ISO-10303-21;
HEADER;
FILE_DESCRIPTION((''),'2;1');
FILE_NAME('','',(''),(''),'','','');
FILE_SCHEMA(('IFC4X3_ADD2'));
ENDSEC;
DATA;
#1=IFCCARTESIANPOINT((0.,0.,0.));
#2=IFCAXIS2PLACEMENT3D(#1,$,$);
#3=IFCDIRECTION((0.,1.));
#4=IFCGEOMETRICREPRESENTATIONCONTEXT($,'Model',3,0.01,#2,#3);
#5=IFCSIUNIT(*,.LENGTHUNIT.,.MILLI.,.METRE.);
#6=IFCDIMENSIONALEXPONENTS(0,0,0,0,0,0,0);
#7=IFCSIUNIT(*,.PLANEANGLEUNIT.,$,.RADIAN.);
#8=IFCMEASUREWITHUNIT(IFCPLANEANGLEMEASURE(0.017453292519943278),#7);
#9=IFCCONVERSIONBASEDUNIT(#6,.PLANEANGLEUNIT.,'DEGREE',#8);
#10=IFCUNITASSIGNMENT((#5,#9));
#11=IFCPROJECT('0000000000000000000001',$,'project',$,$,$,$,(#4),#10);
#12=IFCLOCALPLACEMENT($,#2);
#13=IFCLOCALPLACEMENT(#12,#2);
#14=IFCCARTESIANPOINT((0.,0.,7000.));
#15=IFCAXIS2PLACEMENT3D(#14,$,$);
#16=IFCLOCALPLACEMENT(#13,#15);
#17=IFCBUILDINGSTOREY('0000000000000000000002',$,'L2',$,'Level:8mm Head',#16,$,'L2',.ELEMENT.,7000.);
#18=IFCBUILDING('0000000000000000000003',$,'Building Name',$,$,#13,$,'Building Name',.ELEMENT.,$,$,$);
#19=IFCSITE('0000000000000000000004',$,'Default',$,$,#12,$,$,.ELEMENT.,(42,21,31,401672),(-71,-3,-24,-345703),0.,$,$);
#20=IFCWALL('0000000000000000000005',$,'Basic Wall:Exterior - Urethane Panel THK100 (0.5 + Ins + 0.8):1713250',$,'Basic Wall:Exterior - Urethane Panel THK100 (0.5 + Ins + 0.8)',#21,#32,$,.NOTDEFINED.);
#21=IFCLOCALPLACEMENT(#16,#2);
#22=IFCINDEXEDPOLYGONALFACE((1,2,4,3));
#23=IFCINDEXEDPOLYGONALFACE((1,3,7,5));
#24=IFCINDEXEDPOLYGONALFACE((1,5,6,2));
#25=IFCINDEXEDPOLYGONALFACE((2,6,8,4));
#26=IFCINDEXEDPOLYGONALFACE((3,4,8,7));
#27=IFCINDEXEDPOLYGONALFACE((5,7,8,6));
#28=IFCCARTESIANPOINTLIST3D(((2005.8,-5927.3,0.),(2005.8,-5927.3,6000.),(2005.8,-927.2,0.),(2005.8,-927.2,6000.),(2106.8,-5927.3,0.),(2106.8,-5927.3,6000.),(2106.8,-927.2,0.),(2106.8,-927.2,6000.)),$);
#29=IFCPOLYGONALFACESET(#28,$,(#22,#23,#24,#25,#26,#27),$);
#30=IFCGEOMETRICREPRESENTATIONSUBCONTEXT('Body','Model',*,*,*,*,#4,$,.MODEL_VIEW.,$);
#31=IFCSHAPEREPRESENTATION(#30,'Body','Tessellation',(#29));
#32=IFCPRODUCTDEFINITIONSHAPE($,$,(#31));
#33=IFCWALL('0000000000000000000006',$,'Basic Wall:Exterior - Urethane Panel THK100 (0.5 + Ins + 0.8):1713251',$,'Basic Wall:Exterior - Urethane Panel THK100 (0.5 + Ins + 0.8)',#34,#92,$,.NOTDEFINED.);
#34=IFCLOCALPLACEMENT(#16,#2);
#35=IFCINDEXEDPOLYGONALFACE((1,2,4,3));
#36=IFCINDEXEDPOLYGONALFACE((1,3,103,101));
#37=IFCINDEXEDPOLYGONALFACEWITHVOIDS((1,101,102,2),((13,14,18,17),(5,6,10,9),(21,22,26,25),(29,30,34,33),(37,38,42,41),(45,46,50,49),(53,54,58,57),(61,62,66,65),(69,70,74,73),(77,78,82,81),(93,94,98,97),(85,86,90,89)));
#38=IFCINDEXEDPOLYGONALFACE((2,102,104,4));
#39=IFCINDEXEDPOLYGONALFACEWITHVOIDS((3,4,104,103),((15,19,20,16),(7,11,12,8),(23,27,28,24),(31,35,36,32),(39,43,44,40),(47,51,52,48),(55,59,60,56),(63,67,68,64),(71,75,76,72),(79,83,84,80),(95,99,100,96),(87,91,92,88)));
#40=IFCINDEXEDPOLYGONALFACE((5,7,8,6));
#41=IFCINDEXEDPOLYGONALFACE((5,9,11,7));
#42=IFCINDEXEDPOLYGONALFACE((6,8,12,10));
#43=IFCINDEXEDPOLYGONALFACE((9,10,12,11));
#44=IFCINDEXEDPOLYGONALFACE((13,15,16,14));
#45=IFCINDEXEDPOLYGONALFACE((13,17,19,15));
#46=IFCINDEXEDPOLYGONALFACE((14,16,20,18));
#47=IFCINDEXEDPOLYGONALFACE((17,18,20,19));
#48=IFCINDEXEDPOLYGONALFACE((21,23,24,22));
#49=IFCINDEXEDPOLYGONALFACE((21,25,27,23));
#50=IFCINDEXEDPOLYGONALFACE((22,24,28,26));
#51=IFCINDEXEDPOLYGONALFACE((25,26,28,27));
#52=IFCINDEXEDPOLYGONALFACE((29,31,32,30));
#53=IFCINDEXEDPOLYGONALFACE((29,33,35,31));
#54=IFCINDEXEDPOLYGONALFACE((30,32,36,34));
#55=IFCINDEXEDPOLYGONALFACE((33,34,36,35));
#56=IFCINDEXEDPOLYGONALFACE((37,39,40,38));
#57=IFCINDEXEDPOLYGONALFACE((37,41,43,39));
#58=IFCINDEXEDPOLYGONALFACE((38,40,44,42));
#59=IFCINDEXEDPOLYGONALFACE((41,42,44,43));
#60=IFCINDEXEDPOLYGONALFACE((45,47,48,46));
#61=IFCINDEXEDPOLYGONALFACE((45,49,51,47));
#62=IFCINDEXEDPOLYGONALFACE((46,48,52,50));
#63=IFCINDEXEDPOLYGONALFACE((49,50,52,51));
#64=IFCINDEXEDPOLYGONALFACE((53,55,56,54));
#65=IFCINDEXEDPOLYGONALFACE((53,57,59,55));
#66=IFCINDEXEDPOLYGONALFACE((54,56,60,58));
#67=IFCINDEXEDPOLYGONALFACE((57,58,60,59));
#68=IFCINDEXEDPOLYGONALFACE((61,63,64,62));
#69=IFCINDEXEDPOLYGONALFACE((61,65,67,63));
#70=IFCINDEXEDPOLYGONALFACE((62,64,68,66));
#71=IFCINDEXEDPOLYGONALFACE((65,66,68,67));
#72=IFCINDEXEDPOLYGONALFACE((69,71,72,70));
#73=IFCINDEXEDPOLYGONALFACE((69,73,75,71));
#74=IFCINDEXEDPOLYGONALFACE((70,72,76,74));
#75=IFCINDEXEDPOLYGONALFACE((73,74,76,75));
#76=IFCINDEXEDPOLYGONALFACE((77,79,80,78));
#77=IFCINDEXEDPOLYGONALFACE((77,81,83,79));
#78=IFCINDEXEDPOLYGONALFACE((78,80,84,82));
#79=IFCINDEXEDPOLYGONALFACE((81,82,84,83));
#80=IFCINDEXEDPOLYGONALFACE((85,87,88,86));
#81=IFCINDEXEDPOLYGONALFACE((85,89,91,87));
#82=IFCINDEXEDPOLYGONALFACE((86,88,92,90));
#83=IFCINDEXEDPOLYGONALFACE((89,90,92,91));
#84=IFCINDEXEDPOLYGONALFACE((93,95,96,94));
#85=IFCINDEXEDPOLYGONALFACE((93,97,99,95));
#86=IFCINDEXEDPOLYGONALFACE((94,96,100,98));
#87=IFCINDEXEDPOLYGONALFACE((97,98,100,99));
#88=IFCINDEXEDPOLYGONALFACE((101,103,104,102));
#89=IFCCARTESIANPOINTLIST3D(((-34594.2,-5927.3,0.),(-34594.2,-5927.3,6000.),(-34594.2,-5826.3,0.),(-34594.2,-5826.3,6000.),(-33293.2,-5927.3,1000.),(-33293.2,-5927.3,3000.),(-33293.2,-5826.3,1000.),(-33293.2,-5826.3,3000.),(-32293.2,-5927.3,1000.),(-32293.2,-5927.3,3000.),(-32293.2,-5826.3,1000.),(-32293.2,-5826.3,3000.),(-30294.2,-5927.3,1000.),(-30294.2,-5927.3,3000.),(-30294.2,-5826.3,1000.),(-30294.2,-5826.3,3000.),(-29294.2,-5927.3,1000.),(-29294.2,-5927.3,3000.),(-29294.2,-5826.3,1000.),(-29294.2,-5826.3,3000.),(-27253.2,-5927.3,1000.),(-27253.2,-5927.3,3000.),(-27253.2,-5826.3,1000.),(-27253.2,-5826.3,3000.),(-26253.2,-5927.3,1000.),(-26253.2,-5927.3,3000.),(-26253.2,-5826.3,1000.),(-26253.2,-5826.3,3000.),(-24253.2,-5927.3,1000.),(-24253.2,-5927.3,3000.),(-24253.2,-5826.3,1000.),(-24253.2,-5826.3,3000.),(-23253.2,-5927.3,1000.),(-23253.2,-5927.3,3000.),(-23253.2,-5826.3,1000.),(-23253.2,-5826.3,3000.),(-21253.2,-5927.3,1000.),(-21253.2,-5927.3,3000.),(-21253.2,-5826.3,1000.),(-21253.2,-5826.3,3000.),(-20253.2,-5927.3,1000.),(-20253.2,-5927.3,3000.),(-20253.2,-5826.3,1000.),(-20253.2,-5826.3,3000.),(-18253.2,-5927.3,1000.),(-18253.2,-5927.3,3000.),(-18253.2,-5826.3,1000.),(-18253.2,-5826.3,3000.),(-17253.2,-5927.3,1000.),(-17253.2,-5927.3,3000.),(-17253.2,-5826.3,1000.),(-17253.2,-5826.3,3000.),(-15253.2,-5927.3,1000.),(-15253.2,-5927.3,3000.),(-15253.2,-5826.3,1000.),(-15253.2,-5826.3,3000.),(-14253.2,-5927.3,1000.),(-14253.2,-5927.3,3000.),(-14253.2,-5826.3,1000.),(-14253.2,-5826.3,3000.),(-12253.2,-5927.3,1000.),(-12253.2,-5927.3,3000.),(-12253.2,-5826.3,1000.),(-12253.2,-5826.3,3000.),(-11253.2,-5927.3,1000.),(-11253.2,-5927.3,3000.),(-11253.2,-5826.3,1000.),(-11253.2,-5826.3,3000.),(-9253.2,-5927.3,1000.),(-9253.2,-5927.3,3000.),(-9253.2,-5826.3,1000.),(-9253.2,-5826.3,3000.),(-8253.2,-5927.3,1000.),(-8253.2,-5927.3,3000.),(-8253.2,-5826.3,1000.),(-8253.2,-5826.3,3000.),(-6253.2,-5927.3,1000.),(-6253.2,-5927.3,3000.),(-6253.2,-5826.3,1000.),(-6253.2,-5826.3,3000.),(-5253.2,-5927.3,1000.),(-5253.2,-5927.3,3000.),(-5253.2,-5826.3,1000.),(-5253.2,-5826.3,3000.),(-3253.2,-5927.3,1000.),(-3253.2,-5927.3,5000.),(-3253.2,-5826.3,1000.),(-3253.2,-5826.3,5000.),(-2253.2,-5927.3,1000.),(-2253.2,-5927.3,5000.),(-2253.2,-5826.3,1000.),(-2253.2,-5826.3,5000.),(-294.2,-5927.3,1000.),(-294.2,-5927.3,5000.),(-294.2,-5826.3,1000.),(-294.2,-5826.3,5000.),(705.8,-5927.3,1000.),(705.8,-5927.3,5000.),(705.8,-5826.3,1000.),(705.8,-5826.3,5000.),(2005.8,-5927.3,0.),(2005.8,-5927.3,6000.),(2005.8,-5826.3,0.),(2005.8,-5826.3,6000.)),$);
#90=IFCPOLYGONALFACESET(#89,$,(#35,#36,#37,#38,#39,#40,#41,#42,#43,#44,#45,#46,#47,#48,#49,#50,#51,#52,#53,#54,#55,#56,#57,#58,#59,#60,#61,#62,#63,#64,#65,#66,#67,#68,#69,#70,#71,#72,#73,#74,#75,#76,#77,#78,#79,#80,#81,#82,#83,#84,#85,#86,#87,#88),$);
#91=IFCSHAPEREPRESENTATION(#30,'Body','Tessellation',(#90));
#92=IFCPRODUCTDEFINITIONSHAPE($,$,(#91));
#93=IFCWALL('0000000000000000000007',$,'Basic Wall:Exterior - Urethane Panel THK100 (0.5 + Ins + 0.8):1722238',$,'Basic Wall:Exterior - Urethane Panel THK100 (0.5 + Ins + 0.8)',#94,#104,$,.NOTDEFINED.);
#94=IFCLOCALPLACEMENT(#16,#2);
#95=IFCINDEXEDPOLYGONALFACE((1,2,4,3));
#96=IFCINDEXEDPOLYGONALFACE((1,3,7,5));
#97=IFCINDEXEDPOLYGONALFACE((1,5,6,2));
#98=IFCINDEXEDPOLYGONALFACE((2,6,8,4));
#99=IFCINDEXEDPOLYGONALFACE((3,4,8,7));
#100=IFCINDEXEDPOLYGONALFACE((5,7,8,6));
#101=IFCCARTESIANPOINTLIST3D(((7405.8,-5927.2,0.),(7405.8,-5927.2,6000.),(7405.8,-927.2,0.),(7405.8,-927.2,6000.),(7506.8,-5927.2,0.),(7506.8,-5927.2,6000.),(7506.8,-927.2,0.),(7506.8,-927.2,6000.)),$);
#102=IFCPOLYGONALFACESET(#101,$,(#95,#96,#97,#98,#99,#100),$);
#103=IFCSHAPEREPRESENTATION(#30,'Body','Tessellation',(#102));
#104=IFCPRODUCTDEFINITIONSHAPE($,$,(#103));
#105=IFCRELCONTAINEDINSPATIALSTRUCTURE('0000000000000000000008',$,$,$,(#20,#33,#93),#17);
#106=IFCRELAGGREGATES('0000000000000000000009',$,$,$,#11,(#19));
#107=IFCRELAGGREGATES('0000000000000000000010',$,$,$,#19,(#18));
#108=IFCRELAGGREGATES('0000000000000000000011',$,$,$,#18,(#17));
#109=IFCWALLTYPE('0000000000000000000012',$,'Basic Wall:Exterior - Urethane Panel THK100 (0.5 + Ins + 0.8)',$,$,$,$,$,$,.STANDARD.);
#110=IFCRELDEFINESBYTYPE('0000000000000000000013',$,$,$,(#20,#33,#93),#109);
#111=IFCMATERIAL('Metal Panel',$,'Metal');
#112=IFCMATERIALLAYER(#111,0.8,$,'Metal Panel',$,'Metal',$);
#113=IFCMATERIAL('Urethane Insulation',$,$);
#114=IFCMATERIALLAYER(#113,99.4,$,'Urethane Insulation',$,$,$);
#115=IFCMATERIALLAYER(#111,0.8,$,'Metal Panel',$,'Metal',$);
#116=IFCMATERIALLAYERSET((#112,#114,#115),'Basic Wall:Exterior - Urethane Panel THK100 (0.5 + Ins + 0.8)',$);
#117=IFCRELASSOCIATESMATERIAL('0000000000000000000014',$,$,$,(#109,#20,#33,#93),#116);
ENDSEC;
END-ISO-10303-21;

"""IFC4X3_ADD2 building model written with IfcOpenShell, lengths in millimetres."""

from ifc_helpers import new_model, entity, si_unit, converted_unit, direction, frame, frame_2d, origin, place, context, subcontext, project, spatial, rectangle, extrude, material, layer, layer_set, type_object, element, save


model = new_model("IFC4X3_ADD2")

# Units and contexts
model_context = context("Model", 3, precision=0.01, world=origin(), true_north=direction((0.0, 1.0)))
body_context = subcontext(model_context, "Body", "Model", "MODEL_VIEW")
ifc_project = project(units=[si_unit("LENGTHUNIT", "METRE", prefix="MILLI"), converted_unit("PLANEANGLEUNIT", "DEGREE", entity("IfcPlaneAngleMeasure", 0.017453292519943278), si_unit("PLANEANGLEUNIT", "RADIAN"), dimensions=[0, 0, 0, 0, 0, 0, 0])], contexts=[model_context])

# Site, building, storey
site_placement = place(None, origin())
site = spatial("IfcSite", under=ifc_project, at=site_placement, Name="Default", CompositionType="ELEMENT", RefLatitude=(42, 21, 31, 401672), RefLongitude=(-71, -3, -24, -345703), RefElevation=0.0)
building_placement = place(site_placement, origin())
building = spatial("IfcBuilding", under=site, at=building_placement, Name="Building Name", LongName="Building Name", CompositionType="ELEMENT")
storey_placement = place(building_placement, frame((0.0, 0.0, 7000.0)))
storey = spatial("IfcBuildingStorey", under=building, at=storey_placement, Name="L2", ObjectType="Level:8mm Head", LongName="L2", CompositionType="ELEMENT", Elevation=7000.0)

# Wall
ifc_material_1 = material(Name="Metal Panel", Category="Metal")
ifc_layer_1 = layer(ifc_material_1, 0.8, Name="Metal Panel", Category="Metal")
ifc_material_2 = material(Name="Urethane Insulation")
ifc_layer_2 = layer(ifc_material_2, 99.4, Name="Urethane Insulation")
ifc_layer_3 = layer(ifc_material_1, 0.8, Name="Metal Panel", Category="Metal")
ifc_layer_set = layer_set([ifc_layer_1, ifc_layer_2, ifc_layer_3], Name="Basic Wall:Exterior - Urethane Panel THK100 (0.5 + Ins + 0.8)")
wall_type = type_object("IfcWallType", Name="Basic Wall:Exterior - Urethane Panel THK100 (0.5 + Ins + 0.8)", PredefinedType="STANDARD", material=ifc_layer_set)
wall_1_placement = place(storey_placement, frame((2056.3, -927.2, 0.0), z_axis=(0.0, 0.0, 1.0), x_axis=(0.0, -1.0, 0.0)))
element("IfcWall", 1, at=wall_1_placement, inside=storey, type_object=wall_type, material=ifc_layer_set, Name="Basic Wall:Exterior - Urethane Panel THK100 (0.5 + Ins + 0.8):1713250", ObjectType="Basic Wall:Exterior - Urethane Panel THK100 (0.5 + Ins + 0.8)", PredefinedType="NOTDEFINED", context=body_context, shape_type="SweptSolid", body=[
    extrude(rectangle(XDim=5000.1, YDim=101.0, at=frame_2d((2500.0, 0.0), x_axis=(-1.0, 0.0))), origin(), (0.0, 0.0, 1.0), 6000.0),
])

# Wall, openings
wall_2_placement = place(storey_placement, frame((2005.8, -5876.8, 0.0), z_axis=(0.0, 0.0, 1.0), x_axis=(-1.0, 0.0, 0.0)))
wall_2 = element("IfcWall", 2, at=wall_2_placement, inside=storey, type_object=wall_type, material=ifc_layer_set, Name="Basic Wall:Exterior - Urethane Panel THK100 (0.5 + Ins + 0.8):1713251", ObjectType="Basic Wall:Exterior - Urethane Panel THK100 (0.5 + Ins + 0.8)", PredefinedType="NOTDEFINED", context=body_context, shape_type="SweptSolid", body=[
    extrude(rectangle(XDim=36600.0, YDim=101.0, at=frame_2d((18300.0, 0.0), x_axis=(-1.0, 0.0))), origin(), (0.0, 0.0, 1.0), 6000.0),
])
opening_1_placement = place(wall_2_placement, frame((34299.0, -50.5, 1000.0)))
element("IfcOpeningElement", 3, at=opening_1_placement, cuts=wall_2, PredefinedType="OPENING", context=body_context, shape_type="SweptSolid", body=[
    extrude(rectangle(XDim=2000.0, YDim=1000.0, at=frame_2d((1000.0, 500.0), x_axis=(-1.0, 0.0))), frame((0.0, 0.0, 0.0), z_axis=(0.0, 1.0, 0.0), x_axis=(0.0, 0.0, 1.0)), (0.0, 0.0, 1.0), 101.0),
])
opening_2_placement = place(wall_2_placement, frame((31300.0, -50.5, 1000.0)))
element("IfcOpeningElement", 4, at=opening_2_placement, cuts=wall_2, PredefinedType="OPENING", context=body_context, shape_type="SweptSolid", body=[
    extrude(rectangle(XDim=2000.0, YDim=1000.0, at=frame_2d((1000.0, 500.0), x_axis=(-1.0, 0.0))), frame((0.0, 0.0, 0.0), z_axis=(0.0, 1.0, 0.0), x_axis=(0.0, 0.0, 1.0)), (0.0, 0.0, 1.0), 101.0),
])
opening_3_placement = place(wall_2_placement, frame((28259.0, -50.5, 1000.0)))
element("IfcOpeningElement", 5, at=opening_3_placement, cuts=wall_2, PredefinedType="OPENING", context=body_context, shape_type="SweptSolid", body=[
    extrude(rectangle(XDim=2000.0, YDim=1000.0, at=frame_2d((1000.0, 500.0), x_axis=(-1.0, 0.0))), frame((0.0, 0.0, 0.0), z_axis=(0.0, 1.0, 0.0), x_axis=(0.0, 0.0, 1.0)), (0.0, 0.0, 1.0), 101.0),
])
opening_4_placement = place(wall_2_placement, frame((25259.0, -50.5, 1000.0)))
element("IfcOpeningElement", 6, at=opening_4_placement, cuts=wall_2, PredefinedType="OPENING", context=body_context, shape_type="SweptSolid", body=[
    extrude(rectangle(XDim=2000.0, YDim=1000.0, at=frame_2d((1000.0, 500.0), x_axis=(-1.0, 0.0))), frame((0.0, 0.0, 0.0), z_axis=(0.0, 1.0, 0.0), x_axis=(0.0, 0.0, 1.0)), (0.0, 0.0, 1.0), 101.0),
])
opening_5_placement = place(wall_2_placement, frame((22259.0, -50.5, 1000.0)))
element("IfcOpeningElement", 7, at=opening_5_placement, cuts=wall_2, PredefinedType="OPENING", context=body_context, shape_type="SweptSolid", body=[
    extrude(rectangle(XDim=2000.0, YDim=1000.0, at=frame_2d((1000.0, 500.0), x_axis=(-1.0, 0.0))), frame((0.0, 0.0, 0.0), z_axis=(0.0, 1.0, 0.0), x_axis=(0.0, 0.0, 1.0)), (0.0, 0.0, 1.0), 101.0),
])
opening_6_placement = place(wall_2_placement, frame((19259.0, -50.5, 1000.0)))
element("IfcOpeningElement", 8, at=opening_6_placement, cuts=wall_2, PredefinedType="OPENING", context=body_context, shape_type="SweptSolid", body=[
    extrude(rectangle(XDim=2000.0, YDim=1000.0, at=frame_2d((1000.0, 500.0), x_axis=(-1.0, 0.0))), frame((0.0, 0.0, 0.0), z_axis=(0.0, 1.0, 0.0), x_axis=(0.0, 0.0, 1.0)), (0.0, 0.0, 1.0), 101.0),
])
opening_7_placement = place(wall_2_placement, frame((16259.0, -50.5, 1000.0)))
element("IfcOpeningElement", 9, at=opening_7_placement, cuts=wall_2, PredefinedType="OPENING", context=body_context, shape_type="SweptSolid", body=[
    extrude(rectangle(XDim=2000.0, YDim=1000.0, at=frame_2d((1000.0, 500.0), x_axis=(-1.0, 0.0))), frame((0.0, 0.0, 0.0), z_axis=(0.0, 1.0, 0.0), x_axis=(0.0, 0.0, 1.0)), (0.0, 0.0, 1.0), 101.0),
])
opening_8_placement = place(wall_2_placement, frame((13259.0, -50.5, 1000.0)))
element("IfcOpeningElement", 10, at=opening_8_placement, cuts=wall_2, PredefinedType="OPENING", context=body_context, shape_type="SweptSolid", body=[
    extrude(rectangle(XDim=2000.0, YDim=1000.0, at=frame_2d((1000.0, 500.0), x_axis=(-1.0, 0.0))), frame((0.0, 0.0, 0.0), z_axis=(0.0, 1.0, 0.0), x_axis=(0.0, 0.0, 1.0)), (0.0, 0.0, 1.0), 101.0),
])
opening_9_placement = place(wall_2_placement, frame((10259.0, -50.5, 1000.0)))
element("IfcOpeningElement", 11, at=opening_9_placement, cuts=wall_2, PredefinedType="OPENING", context=body_context, shape_type="SweptSolid", body=[
    extrude(rectangle(XDim=2000.0, YDim=1000.0, at=frame_2d((1000.0, 500.0), x_axis=(-1.0, 0.0))), frame((0.0, 0.0, 0.0), z_axis=(0.0, 1.0, 0.0), x_axis=(0.0, 0.0, 1.0)), (0.0, 0.0, 1.0), 101.0),
])
opening_10_placement = place(wall_2_placement, frame((7259.0, -50.5, 1000.0)))
element("IfcOpeningElement", 12, at=opening_10_placement, cuts=wall_2, PredefinedType="OPENING", context=body_context, shape_type="SweptSolid", body=[
    extrude(rectangle(XDim=2000.0, YDim=1000.0, at=frame_2d((1000.0, 500.0), x_axis=(-1.0, 0.0))), frame((0.0, 0.0, 0.0), z_axis=(0.0, 1.0, 0.0), x_axis=(0.0, 0.0, 1.0)), (0.0, 0.0, 1.0), 101.0),
])
opening_11_placement = place(wall_2_placement, frame((4259.0, -50.5, 1000.0)))
element("IfcOpeningElement", 13, at=opening_11_placement, cuts=wall_2, PredefinedType="OPENING", context=body_context, shape_type="SweptSolid", body=[
    extrude(rectangle(XDim=4000.0, YDim=1000.0, at=frame_2d((2000.0, 500.0), x_axis=(-1.0, 0.0))), frame((0.0, 0.0, 0.0), z_axis=(0.0, 1.0, 0.0), x_axis=(0.0, 0.0, 1.0)), (0.0, 0.0, 1.0), 101.0),
])
opening_12_placement = place(wall_2_placement, frame((1300.0, -50.5, 1000.0)))
element("IfcOpeningElement", 14, at=opening_12_placement, cuts=wall_2, PredefinedType="OPENING", context=body_context, shape_type="SweptSolid", body=[
    extrude(rectangle(XDim=4000.0, YDim=1000.0, at=frame_2d((2000.0, 500.0), x_axis=(-1.0, 0.0))), frame((0.0, 0.0, 0.0), z_axis=(0.0, 1.0, 0.0), x_axis=(0.0, 0.0, 1.0)), (0.0, 0.0, 1.0), 101.0),
])

# Wall
wall_3_placement = place(storey_placement, frame((7456.3, -927.2, 0.0), z_axis=(0.0, 0.0, 1.0), x_axis=(0.0, -1.0, 0.0)))
element("IfcWall", 15, at=wall_3_placement, inside=storey, type_object=wall_type, material=ifc_layer_set, Name="Basic Wall:Exterior - Urethane Panel THK100 (0.5 + Ins + 0.8):1722238", ObjectType="Basic Wall:Exterior - Urethane Panel THK100 (0.5 + Ins + 0.8)", PredefinedType="NOTDEFINED", context=body_context, shape_type="SweptSolid", body=[
    extrude(rectangle(XDim=5000.0, YDim=101.0, at=frame_2d((2500.0, 0.0), x_axis=(-1.0, 0.0))), origin(), (0.0, 0.0, 1.0), 6000.0),
])

save(model, "model.ifc")
